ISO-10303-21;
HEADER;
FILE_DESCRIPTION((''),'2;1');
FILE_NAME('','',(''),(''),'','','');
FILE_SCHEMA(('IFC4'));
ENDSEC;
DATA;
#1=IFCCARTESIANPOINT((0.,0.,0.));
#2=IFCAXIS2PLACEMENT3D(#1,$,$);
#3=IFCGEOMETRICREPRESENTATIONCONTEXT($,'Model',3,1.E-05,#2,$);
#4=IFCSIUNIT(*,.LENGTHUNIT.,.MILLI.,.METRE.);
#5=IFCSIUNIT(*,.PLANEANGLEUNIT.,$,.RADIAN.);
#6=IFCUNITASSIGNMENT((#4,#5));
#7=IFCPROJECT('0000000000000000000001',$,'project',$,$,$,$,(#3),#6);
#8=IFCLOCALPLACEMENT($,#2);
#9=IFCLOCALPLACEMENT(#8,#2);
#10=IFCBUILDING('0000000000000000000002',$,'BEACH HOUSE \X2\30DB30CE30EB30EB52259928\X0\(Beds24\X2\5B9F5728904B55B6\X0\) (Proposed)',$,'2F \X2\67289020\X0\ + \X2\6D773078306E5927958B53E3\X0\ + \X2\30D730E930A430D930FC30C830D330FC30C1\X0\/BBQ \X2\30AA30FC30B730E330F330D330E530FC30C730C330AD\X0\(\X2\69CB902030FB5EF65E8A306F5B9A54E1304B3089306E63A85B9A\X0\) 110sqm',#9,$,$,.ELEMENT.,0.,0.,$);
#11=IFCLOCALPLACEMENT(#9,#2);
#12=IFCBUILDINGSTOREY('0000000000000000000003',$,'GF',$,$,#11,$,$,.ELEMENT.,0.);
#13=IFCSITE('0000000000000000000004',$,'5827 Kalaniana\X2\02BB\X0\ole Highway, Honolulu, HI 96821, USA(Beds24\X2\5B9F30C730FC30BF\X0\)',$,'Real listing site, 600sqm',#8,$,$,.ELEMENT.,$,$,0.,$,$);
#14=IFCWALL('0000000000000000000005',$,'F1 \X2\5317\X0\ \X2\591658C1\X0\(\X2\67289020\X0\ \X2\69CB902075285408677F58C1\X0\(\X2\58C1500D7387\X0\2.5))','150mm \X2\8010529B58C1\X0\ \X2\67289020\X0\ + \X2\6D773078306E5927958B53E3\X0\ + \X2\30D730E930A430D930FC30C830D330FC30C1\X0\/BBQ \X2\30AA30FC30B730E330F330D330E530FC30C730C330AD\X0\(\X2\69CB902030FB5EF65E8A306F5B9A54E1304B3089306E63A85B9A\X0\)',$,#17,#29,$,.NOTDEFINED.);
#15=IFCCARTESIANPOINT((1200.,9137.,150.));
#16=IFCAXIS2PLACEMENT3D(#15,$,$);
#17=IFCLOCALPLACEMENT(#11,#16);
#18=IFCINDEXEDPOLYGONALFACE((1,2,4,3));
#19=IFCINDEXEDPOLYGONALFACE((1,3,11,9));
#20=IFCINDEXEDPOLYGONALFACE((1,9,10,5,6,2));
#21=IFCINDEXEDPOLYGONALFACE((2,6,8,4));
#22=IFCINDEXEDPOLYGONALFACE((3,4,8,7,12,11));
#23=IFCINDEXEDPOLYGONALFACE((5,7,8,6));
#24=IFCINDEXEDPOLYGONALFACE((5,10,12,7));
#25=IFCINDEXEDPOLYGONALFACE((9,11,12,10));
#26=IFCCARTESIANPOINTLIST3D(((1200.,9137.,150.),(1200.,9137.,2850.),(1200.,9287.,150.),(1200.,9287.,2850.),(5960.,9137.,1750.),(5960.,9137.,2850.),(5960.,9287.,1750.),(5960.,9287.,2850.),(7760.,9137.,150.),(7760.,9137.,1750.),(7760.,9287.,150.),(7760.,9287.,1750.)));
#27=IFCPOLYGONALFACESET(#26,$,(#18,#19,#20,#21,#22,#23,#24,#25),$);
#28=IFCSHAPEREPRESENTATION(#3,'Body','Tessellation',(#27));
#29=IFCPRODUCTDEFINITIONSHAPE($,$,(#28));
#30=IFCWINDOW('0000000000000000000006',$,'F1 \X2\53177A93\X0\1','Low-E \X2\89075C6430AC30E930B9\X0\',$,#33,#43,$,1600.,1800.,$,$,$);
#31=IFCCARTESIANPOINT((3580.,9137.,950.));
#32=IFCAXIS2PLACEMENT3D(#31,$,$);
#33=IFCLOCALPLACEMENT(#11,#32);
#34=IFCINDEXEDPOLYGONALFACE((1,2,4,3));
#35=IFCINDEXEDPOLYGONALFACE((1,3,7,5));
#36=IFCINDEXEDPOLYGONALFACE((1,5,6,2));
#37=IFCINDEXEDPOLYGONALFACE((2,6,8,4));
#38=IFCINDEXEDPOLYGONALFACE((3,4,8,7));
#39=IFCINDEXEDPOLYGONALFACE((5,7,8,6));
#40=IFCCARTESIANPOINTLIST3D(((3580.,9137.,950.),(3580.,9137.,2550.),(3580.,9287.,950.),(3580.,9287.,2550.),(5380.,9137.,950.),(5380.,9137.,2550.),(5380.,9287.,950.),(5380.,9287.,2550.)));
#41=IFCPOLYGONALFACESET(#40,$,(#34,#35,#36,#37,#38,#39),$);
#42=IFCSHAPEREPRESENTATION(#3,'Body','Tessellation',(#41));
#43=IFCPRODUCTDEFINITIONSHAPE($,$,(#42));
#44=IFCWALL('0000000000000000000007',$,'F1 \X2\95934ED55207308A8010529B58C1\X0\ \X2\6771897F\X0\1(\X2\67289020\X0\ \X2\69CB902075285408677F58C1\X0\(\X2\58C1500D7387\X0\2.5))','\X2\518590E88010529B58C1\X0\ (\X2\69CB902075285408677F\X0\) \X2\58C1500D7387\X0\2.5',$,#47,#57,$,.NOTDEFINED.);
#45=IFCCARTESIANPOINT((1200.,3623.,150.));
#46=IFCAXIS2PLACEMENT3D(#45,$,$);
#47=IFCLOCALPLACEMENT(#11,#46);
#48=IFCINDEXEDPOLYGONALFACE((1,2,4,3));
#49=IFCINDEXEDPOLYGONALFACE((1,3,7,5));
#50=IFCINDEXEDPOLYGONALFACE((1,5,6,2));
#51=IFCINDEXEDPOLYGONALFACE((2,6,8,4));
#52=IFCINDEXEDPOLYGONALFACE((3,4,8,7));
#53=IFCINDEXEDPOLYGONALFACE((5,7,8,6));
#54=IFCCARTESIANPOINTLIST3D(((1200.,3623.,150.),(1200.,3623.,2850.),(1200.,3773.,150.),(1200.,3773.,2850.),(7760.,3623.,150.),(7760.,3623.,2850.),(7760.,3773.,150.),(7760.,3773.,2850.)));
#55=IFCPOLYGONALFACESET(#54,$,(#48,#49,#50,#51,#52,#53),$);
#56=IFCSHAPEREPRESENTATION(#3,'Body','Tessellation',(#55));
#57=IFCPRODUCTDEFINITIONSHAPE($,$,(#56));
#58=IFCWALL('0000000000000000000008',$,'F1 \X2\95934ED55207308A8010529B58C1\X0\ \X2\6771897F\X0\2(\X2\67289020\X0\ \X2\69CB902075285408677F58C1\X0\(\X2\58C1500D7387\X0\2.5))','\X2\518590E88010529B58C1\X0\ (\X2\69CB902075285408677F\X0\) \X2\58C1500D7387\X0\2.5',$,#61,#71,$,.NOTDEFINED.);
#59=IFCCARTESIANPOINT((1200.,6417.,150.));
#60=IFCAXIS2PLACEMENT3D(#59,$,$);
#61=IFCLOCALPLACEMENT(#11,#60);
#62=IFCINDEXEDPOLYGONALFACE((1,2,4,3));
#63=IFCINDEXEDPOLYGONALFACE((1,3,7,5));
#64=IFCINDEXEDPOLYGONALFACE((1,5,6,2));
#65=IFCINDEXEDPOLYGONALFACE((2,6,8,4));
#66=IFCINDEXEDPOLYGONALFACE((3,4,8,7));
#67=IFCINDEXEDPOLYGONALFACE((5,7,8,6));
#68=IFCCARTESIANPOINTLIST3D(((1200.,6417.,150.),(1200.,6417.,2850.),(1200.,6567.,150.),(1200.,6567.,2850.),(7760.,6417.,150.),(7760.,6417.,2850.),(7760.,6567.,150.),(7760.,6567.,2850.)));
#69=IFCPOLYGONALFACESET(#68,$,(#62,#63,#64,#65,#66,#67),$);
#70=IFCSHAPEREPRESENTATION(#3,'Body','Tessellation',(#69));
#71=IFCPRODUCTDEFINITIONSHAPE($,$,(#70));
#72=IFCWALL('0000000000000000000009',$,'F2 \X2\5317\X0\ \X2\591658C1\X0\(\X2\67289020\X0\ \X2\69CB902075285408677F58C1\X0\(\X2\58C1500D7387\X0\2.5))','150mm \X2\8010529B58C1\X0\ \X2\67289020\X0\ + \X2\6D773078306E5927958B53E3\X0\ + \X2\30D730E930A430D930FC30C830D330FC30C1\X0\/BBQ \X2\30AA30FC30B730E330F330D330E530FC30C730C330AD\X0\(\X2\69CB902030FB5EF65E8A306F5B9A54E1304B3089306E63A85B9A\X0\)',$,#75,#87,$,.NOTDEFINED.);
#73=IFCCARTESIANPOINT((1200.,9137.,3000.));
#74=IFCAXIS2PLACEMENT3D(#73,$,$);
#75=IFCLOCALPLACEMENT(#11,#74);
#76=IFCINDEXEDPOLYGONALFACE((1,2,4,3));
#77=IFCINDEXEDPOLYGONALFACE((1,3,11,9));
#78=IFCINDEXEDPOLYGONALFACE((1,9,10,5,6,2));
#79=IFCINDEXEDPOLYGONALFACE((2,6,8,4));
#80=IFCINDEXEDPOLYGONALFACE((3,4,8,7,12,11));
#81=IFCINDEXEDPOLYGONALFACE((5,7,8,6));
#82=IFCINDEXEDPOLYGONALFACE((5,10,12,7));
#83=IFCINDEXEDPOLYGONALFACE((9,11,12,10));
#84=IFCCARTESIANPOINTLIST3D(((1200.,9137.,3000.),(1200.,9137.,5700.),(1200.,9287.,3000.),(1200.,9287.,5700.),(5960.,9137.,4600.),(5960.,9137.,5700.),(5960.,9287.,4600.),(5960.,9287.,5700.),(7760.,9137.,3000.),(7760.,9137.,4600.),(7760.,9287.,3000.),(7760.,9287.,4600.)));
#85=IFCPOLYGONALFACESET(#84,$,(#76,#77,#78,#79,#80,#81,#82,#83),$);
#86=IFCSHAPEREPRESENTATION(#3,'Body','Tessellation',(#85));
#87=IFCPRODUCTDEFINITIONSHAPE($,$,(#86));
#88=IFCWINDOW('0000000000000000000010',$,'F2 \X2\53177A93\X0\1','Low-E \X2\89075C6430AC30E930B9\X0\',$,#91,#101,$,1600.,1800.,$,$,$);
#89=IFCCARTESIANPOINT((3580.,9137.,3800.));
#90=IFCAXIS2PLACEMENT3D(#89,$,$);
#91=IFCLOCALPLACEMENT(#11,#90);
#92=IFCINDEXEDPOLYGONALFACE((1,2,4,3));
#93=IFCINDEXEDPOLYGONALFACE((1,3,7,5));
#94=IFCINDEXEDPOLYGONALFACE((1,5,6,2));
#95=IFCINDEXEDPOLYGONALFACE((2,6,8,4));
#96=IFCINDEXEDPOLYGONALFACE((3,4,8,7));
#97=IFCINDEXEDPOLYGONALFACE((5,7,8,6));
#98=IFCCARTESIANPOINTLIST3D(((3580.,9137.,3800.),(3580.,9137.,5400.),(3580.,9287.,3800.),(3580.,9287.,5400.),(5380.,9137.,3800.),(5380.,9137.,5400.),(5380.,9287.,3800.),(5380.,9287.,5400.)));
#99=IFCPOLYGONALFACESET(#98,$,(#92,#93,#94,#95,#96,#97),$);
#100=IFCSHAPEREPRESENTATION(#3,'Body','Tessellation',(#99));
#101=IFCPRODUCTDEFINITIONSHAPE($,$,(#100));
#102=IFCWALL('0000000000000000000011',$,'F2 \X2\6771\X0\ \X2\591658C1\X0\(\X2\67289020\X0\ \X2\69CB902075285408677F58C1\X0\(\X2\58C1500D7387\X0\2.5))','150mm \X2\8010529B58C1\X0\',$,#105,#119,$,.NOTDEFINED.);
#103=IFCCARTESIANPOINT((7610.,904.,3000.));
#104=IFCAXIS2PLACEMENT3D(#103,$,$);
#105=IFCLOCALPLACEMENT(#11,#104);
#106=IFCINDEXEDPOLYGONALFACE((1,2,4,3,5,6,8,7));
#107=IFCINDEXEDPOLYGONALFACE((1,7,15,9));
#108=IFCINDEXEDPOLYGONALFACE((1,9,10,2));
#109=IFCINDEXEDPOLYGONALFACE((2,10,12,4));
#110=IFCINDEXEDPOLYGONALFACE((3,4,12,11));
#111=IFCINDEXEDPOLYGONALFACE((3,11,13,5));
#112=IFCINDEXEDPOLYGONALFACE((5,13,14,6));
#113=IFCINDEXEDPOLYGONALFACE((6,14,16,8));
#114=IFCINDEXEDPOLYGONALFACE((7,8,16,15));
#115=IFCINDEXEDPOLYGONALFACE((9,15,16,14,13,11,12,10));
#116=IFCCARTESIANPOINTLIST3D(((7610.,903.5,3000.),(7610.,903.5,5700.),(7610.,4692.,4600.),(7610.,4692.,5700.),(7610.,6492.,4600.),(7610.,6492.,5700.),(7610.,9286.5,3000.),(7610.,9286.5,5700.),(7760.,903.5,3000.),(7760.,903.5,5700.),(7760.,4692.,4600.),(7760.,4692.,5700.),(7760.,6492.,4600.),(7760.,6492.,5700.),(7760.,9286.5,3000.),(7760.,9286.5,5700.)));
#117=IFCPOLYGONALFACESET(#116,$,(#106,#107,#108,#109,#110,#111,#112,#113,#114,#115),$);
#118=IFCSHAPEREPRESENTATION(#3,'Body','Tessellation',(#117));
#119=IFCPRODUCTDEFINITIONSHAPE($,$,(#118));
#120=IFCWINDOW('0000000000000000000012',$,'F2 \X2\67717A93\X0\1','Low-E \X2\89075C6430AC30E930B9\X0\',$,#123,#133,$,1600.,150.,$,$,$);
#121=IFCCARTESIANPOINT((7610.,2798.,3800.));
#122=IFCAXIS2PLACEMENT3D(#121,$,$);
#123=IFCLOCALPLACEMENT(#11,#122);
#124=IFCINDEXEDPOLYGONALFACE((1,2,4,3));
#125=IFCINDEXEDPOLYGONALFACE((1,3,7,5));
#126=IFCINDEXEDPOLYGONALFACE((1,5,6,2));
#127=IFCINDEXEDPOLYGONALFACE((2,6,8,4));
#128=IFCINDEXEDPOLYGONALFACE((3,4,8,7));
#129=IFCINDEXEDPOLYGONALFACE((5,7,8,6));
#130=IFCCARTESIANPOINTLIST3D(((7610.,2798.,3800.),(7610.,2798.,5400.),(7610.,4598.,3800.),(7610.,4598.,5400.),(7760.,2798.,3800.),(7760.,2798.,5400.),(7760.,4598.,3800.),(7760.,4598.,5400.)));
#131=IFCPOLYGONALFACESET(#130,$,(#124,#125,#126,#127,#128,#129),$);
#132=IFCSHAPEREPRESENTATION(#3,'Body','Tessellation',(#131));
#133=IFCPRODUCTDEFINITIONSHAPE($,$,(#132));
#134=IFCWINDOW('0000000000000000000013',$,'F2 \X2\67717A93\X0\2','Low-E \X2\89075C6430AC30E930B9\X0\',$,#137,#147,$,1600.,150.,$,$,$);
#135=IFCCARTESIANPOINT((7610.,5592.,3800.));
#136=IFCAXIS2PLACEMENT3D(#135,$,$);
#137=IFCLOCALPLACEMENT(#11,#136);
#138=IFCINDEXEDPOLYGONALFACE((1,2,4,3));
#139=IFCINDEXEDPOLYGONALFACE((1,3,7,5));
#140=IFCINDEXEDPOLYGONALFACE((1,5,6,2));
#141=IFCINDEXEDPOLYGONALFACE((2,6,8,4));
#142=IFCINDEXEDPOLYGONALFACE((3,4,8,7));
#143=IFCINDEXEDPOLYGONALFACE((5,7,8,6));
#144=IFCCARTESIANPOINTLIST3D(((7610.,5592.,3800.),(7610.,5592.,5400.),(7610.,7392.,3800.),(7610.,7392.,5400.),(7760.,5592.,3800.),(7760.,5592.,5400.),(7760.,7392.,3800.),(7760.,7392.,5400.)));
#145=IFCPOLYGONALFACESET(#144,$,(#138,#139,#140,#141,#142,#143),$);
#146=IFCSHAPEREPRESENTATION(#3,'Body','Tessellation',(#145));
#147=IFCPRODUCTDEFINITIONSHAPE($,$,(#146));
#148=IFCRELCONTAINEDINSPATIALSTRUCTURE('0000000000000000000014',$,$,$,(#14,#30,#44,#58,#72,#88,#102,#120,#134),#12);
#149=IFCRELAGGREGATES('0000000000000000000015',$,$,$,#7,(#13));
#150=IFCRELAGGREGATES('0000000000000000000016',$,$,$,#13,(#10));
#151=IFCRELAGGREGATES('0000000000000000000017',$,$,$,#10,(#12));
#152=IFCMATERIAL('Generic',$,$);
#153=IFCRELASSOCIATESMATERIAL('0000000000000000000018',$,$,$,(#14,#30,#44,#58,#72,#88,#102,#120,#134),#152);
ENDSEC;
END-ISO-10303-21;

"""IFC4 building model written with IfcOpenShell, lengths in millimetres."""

from ifc_helpers import new_model, si_unit, frame, frame_2d, origin, place, context, project, spatial, rectangle, extrude, material, element, fill, save


model = new_model("IFC4")

# Units and contexts
model_context = context("Model", 3, precision=1e-05, world=origin())
ifc_project = project(units=[si_unit("LENGTHUNIT", "METRE", prefix="MILLI"), si_unit("PLANEANGLEUNIT", "RADIAN")], contexts=[model_context])

# Site, building, storey
site_placement = place(None, origin())
site = spatial("IfcSite", under=ifc_project, at=site_placement, Name="5827 Kalanianaʻole Highway, Honolulu, HI 96821, USA(Beds24実データ)", ObjectType="Real listing site, 600sqm", CompositionType="ELEMENT", RefElevation=0.0)
building_placement = place(site_placement, origin())
building = spatial("IfcBuilding", under=site, at=building_placement, Name="BEACH HOUSE ホノルル別館(Beds24実在運営) (Proposed)", ObjectType="2F 木造 + 海への大開口 + プライベートビーチ/BBQ オーシャンビューデッキ(構造・延床は定員からの推定) 110sqm", CompositionType="ELEMENT", ElevationOfRefHeight=0.0, ElevationOfTerrain=0.0)
storey_placement = place(building_placement, origin())
storey = spatial("IfcBuildingStorey", under=building, at=storey_placement, Name="GF", CompositionType="ELEMENT", Elevation=0.0)

# Wall, opening, window
ifc_material_1 = material(Name="Generic")
wall_1_placement = place(storey_placement, frame((1200.0, 9137.0, 150.0)))
wall_1 = element("IfcWall", 1, at=wall_1_placement, inside=storey, material=ifc_material_1, Name="F1 北 外壁(木造 構造用合板壁(壁倍率2.5))", Description="150mm 耐力壁 木造 + 海への大開口 + プライベートビーチ/BBQ オーシャンビューデッキ(構造・延床は定員からの推定)", PredefinedType="NOTDEFINED", context=model_context, shape_type="SweptSolid", body=[
    extrude(rectangle(XDim=6560.0, YDim=150.0, at=frame_2d((3280.0, 75.0))), frame((1200.0, 9137.0, 150.0)), (0.0, 0.0, 1.0), 2700.0),
])
opening_1_placement = place(storey_placement, frame((3580.0, 9137.0, 950.0)))
opening_1 = element("IfcOpeningElement", 2, at=opening_1_placement, cuts=wall_1, PredefinedType="NOTDEFINED", context=model_context, shape_type="SweptSolid", body=[
    extrude(rectangle(XDim=1800.0, YDim=150.0, at=frame_2d((900.0, 75.0))), frame((3580.0, 9137.0, 950.0)), (0.0, 0.0, 1.0), 1600.0),
])
window_1_placement = place(storey_placement, frame((3580.0, 9137.0, 950.0)))
window_1 = element("IfcWindow", 3, at=window_1_placement, inside=storey, material=ifc_material_1, Name="F1 北窓1", Description="Low-E 複層ガラス", OverallHeight=1600.0, OverallWidth=1800.0, context=model_context, shape_type="SweptSolid", body=[
    extrude(rectangle(XDim=1800.0, YDim=150.0, at=frame_2d((900.0, 75.0))), frame((3580.0, 9137.0, 950.0)), (0.0, 0.0, 1.0), 1600.0),
])
fill(opening_1, window_1)

# Walls
wall_2_placement = place(storey_placement, frame((1200.0, 3623.0, 150.0)))
element("IfcWall", 4, at=wall_2_placement, inside=storey, material=ifc_material_1, Name="F1 間仕切り耐力壁 東西1(木造 構造用合板壁(壁倍率2.5))", Description="内部耐力壁 (構造用合板) 壁倍率2.5", PredefinedType="NOTDEFINED", context=model_context, shape_type="SweptSolid", body=[
    extrude(rectangle(XDim=6560.0, YDim=150.0, at=frame_2d((3280.0, 75.0))), frame((1200.0, 3623.0, 150.0)), (0.0, 0.0, 1.0), 2700.0),
])
wall_3_placement = place(storey_placement, frame((1200.0, 6417.0, 150.0)))
element("IfcWall", 5, at=wall_3_placement, inside=storey, material=ifc_material_1, Name="F1 間仕切り耐力壁 東西2(木造 構造用合板壁(壁倍率2.5))", Description="内部耐力壁 (構造用合板) 壁倍率2.5", PredefinedType="NOTDEFINED", context=model_context, shape_type="SweptSolid", body=[
    extrude(rectangle(XDim=6560.0, YDim=150.0, at=frame_2d((3280.0, 75.0))), frame((1200.0, 6417.0, 150.0)), (0.0, 0.0, 1.0), 2700.0),
])

# Wall, opening, window
wall_4_placement = place(storey_placement, frame((1200.0, 9137.0, 3000.0)))
wall_4 = element("IfcWall", 6, at=wall_4_placement, inside=storey, material=ifc_material_1, Name="F2 北 外壁(木造 構造用合板壁(壁倍率2.5))", Description="150mm 耐力壁 木造 + 海への大開口 + プライベートビーチ/BBQ オーシャンビューデッキ(構造・延床は定員からの推定)", PredefinedType="NOTDEFINED", context=model_context, shape_type="SweptSolid", body=[
    extrude(rectangle(XDim=6560.0, YDim=150.0, at=frame_2d((3280.0, 75.0))), frame((1200.0, 9137.0, 3000.0)), (0.0, 0.0, 1.0), 2700.0),
])
opening_2_placement = place(storey_placement, frame((3580.0, 9137.0, 3800.0)))
opening_2 = element("IfcOpeningElement", 7, at=opening_2_placement, cuts=wall_4, PredefinedType="NOTDEFINED", context=model_context, shape_type="SweptSolid", body=[
    extrude(rectangle(XDim=1800.0, YDim=150.0, at=frame_2d((900.0, 75.0))), frame((3580.0, 9137.0, 3800.0)), (0.0, 0.0, 1.0), 1600.0),
])
window_2_placement = place(storey_placement, frame((3580.0, 9137.0, 3800.0)))
window_2 = element("IfcWindow", 8, at=window_2_placement, inside=storey, material=ifc_material_1, Name="F2 北窓1", Description="Low-E 複層ガラス", OverallHeight=1600.0, OverallWidth=1800.0, context=model_context, shape_type="SweptSolid", body=[
    extrude(rectangle(XDim=1800.0, YDim=150.0, at=frame_2d((900.0, 75.0))), frame((3580.0, 9137.0, 3800.0)), (0.0, 0.0, 1.0), 1600.0),
])
fill(opening_2, window_2)

# Wall, openings, windows
wall_5_placement = place(storey_placement, frame((7610.0, 904.0, 3000.0)))
wall_5 = element("IfcWall", 9, at=wall_5_placement, inside=storey, material=ifc_material_1, Name="F2 東 外壁(木造 構造用合板壁(壁倍率2.5))", Description="150mm 耐力壁", PredefinedType="NOTDEFINED", context=model_context, shape_type="SweptSolid", body=[
    extrude(rectangle(XDim=150.0, YDim=8383.0, at=frame_2d((75.0, 4191.0))), frame((7610.0, 904.0, 3000.0)), (0.0, 0.0, 1.0), 2700.0),
])
opening_3_placement = place(storey_placement, frame((7610.0, 2798.0, 3800.0)))
opening_3 = element("IfcOpeningElement", 10, at=opening_3_placement, cuts=wall_5, PredefinedType="NOTDEFINED", context=model_context, shape_type="SweptSolid", body=[
    extrude(rectangle(XDim=150.0, YDim=1800.0, at=frame_2d((75.0, 900.0))), frame((7610.0, 2798.0, 3800.0)), (0.0, 0.0, 1.0), 1600.0),
])
opening_4_placement = place(storey_placement, frame((7610.0, 5592.0, 3800.0)))
opening_4 = element("IfcOpeningElement", 11, at=opening_4_placement, cuts=wall_5, PredefinedType="NOTDEFINED", context=model_context, shape_type="SweptSolid", body=[
    extrude(rectangle(XDim=150.0, YDim=1800.0, at=frame_2d((75.0, 900.0))), frame((7610.0, 5592.0, 3800.0)), (0.0, 0.0, 1.0), 1600.0),
])
window_3_placement = place(storey_placement, frame((7610.0, 2798.0, 3800.0)))
window_3 = element("IfcWindow", 12, at=window_3_placement, inside=storey, material=ifc_material_1, Name="F2 東窓1", Description="Low-E 複層ガラス", OverallHeight=1600.0, OverallWidth=150.0, context=model_context, shape_type="SweptSolid", body=[
    extrude(rectangle(XDim=150.0, YDim=1800.0, at=frame_2d((75.0, 900.0))), frame((7610.0, 2798.0, 3800.0)), (0.0, 0.0, 1.0), 1600.0),
])
fill(opening_3, window_3)
window_4_placement = place(storey_placement, frame((7610.0, 5592.0, 3800.0)))
window_4 = element("IfcWindow", 13, at=window_4_placement, inside=storey, material=ifc_material_1, Name="F2 東窓2", Description="Low-E 複層ガラス", OverallHeight=1600.0, OverallWidth=150.0, context=model_context, shape_type="SweptSolid", body=[
    extrude(rectangle(XDim=150.0, YDim=1800.0, at=frame_2d((75.0, 900.0))), frame((7610.0, 5592.0, 3800.0)), (0.0, 0.0, 1.0), 1600.0),
])
fill(opening_4, window_4)

save(model, "model.ifc")
